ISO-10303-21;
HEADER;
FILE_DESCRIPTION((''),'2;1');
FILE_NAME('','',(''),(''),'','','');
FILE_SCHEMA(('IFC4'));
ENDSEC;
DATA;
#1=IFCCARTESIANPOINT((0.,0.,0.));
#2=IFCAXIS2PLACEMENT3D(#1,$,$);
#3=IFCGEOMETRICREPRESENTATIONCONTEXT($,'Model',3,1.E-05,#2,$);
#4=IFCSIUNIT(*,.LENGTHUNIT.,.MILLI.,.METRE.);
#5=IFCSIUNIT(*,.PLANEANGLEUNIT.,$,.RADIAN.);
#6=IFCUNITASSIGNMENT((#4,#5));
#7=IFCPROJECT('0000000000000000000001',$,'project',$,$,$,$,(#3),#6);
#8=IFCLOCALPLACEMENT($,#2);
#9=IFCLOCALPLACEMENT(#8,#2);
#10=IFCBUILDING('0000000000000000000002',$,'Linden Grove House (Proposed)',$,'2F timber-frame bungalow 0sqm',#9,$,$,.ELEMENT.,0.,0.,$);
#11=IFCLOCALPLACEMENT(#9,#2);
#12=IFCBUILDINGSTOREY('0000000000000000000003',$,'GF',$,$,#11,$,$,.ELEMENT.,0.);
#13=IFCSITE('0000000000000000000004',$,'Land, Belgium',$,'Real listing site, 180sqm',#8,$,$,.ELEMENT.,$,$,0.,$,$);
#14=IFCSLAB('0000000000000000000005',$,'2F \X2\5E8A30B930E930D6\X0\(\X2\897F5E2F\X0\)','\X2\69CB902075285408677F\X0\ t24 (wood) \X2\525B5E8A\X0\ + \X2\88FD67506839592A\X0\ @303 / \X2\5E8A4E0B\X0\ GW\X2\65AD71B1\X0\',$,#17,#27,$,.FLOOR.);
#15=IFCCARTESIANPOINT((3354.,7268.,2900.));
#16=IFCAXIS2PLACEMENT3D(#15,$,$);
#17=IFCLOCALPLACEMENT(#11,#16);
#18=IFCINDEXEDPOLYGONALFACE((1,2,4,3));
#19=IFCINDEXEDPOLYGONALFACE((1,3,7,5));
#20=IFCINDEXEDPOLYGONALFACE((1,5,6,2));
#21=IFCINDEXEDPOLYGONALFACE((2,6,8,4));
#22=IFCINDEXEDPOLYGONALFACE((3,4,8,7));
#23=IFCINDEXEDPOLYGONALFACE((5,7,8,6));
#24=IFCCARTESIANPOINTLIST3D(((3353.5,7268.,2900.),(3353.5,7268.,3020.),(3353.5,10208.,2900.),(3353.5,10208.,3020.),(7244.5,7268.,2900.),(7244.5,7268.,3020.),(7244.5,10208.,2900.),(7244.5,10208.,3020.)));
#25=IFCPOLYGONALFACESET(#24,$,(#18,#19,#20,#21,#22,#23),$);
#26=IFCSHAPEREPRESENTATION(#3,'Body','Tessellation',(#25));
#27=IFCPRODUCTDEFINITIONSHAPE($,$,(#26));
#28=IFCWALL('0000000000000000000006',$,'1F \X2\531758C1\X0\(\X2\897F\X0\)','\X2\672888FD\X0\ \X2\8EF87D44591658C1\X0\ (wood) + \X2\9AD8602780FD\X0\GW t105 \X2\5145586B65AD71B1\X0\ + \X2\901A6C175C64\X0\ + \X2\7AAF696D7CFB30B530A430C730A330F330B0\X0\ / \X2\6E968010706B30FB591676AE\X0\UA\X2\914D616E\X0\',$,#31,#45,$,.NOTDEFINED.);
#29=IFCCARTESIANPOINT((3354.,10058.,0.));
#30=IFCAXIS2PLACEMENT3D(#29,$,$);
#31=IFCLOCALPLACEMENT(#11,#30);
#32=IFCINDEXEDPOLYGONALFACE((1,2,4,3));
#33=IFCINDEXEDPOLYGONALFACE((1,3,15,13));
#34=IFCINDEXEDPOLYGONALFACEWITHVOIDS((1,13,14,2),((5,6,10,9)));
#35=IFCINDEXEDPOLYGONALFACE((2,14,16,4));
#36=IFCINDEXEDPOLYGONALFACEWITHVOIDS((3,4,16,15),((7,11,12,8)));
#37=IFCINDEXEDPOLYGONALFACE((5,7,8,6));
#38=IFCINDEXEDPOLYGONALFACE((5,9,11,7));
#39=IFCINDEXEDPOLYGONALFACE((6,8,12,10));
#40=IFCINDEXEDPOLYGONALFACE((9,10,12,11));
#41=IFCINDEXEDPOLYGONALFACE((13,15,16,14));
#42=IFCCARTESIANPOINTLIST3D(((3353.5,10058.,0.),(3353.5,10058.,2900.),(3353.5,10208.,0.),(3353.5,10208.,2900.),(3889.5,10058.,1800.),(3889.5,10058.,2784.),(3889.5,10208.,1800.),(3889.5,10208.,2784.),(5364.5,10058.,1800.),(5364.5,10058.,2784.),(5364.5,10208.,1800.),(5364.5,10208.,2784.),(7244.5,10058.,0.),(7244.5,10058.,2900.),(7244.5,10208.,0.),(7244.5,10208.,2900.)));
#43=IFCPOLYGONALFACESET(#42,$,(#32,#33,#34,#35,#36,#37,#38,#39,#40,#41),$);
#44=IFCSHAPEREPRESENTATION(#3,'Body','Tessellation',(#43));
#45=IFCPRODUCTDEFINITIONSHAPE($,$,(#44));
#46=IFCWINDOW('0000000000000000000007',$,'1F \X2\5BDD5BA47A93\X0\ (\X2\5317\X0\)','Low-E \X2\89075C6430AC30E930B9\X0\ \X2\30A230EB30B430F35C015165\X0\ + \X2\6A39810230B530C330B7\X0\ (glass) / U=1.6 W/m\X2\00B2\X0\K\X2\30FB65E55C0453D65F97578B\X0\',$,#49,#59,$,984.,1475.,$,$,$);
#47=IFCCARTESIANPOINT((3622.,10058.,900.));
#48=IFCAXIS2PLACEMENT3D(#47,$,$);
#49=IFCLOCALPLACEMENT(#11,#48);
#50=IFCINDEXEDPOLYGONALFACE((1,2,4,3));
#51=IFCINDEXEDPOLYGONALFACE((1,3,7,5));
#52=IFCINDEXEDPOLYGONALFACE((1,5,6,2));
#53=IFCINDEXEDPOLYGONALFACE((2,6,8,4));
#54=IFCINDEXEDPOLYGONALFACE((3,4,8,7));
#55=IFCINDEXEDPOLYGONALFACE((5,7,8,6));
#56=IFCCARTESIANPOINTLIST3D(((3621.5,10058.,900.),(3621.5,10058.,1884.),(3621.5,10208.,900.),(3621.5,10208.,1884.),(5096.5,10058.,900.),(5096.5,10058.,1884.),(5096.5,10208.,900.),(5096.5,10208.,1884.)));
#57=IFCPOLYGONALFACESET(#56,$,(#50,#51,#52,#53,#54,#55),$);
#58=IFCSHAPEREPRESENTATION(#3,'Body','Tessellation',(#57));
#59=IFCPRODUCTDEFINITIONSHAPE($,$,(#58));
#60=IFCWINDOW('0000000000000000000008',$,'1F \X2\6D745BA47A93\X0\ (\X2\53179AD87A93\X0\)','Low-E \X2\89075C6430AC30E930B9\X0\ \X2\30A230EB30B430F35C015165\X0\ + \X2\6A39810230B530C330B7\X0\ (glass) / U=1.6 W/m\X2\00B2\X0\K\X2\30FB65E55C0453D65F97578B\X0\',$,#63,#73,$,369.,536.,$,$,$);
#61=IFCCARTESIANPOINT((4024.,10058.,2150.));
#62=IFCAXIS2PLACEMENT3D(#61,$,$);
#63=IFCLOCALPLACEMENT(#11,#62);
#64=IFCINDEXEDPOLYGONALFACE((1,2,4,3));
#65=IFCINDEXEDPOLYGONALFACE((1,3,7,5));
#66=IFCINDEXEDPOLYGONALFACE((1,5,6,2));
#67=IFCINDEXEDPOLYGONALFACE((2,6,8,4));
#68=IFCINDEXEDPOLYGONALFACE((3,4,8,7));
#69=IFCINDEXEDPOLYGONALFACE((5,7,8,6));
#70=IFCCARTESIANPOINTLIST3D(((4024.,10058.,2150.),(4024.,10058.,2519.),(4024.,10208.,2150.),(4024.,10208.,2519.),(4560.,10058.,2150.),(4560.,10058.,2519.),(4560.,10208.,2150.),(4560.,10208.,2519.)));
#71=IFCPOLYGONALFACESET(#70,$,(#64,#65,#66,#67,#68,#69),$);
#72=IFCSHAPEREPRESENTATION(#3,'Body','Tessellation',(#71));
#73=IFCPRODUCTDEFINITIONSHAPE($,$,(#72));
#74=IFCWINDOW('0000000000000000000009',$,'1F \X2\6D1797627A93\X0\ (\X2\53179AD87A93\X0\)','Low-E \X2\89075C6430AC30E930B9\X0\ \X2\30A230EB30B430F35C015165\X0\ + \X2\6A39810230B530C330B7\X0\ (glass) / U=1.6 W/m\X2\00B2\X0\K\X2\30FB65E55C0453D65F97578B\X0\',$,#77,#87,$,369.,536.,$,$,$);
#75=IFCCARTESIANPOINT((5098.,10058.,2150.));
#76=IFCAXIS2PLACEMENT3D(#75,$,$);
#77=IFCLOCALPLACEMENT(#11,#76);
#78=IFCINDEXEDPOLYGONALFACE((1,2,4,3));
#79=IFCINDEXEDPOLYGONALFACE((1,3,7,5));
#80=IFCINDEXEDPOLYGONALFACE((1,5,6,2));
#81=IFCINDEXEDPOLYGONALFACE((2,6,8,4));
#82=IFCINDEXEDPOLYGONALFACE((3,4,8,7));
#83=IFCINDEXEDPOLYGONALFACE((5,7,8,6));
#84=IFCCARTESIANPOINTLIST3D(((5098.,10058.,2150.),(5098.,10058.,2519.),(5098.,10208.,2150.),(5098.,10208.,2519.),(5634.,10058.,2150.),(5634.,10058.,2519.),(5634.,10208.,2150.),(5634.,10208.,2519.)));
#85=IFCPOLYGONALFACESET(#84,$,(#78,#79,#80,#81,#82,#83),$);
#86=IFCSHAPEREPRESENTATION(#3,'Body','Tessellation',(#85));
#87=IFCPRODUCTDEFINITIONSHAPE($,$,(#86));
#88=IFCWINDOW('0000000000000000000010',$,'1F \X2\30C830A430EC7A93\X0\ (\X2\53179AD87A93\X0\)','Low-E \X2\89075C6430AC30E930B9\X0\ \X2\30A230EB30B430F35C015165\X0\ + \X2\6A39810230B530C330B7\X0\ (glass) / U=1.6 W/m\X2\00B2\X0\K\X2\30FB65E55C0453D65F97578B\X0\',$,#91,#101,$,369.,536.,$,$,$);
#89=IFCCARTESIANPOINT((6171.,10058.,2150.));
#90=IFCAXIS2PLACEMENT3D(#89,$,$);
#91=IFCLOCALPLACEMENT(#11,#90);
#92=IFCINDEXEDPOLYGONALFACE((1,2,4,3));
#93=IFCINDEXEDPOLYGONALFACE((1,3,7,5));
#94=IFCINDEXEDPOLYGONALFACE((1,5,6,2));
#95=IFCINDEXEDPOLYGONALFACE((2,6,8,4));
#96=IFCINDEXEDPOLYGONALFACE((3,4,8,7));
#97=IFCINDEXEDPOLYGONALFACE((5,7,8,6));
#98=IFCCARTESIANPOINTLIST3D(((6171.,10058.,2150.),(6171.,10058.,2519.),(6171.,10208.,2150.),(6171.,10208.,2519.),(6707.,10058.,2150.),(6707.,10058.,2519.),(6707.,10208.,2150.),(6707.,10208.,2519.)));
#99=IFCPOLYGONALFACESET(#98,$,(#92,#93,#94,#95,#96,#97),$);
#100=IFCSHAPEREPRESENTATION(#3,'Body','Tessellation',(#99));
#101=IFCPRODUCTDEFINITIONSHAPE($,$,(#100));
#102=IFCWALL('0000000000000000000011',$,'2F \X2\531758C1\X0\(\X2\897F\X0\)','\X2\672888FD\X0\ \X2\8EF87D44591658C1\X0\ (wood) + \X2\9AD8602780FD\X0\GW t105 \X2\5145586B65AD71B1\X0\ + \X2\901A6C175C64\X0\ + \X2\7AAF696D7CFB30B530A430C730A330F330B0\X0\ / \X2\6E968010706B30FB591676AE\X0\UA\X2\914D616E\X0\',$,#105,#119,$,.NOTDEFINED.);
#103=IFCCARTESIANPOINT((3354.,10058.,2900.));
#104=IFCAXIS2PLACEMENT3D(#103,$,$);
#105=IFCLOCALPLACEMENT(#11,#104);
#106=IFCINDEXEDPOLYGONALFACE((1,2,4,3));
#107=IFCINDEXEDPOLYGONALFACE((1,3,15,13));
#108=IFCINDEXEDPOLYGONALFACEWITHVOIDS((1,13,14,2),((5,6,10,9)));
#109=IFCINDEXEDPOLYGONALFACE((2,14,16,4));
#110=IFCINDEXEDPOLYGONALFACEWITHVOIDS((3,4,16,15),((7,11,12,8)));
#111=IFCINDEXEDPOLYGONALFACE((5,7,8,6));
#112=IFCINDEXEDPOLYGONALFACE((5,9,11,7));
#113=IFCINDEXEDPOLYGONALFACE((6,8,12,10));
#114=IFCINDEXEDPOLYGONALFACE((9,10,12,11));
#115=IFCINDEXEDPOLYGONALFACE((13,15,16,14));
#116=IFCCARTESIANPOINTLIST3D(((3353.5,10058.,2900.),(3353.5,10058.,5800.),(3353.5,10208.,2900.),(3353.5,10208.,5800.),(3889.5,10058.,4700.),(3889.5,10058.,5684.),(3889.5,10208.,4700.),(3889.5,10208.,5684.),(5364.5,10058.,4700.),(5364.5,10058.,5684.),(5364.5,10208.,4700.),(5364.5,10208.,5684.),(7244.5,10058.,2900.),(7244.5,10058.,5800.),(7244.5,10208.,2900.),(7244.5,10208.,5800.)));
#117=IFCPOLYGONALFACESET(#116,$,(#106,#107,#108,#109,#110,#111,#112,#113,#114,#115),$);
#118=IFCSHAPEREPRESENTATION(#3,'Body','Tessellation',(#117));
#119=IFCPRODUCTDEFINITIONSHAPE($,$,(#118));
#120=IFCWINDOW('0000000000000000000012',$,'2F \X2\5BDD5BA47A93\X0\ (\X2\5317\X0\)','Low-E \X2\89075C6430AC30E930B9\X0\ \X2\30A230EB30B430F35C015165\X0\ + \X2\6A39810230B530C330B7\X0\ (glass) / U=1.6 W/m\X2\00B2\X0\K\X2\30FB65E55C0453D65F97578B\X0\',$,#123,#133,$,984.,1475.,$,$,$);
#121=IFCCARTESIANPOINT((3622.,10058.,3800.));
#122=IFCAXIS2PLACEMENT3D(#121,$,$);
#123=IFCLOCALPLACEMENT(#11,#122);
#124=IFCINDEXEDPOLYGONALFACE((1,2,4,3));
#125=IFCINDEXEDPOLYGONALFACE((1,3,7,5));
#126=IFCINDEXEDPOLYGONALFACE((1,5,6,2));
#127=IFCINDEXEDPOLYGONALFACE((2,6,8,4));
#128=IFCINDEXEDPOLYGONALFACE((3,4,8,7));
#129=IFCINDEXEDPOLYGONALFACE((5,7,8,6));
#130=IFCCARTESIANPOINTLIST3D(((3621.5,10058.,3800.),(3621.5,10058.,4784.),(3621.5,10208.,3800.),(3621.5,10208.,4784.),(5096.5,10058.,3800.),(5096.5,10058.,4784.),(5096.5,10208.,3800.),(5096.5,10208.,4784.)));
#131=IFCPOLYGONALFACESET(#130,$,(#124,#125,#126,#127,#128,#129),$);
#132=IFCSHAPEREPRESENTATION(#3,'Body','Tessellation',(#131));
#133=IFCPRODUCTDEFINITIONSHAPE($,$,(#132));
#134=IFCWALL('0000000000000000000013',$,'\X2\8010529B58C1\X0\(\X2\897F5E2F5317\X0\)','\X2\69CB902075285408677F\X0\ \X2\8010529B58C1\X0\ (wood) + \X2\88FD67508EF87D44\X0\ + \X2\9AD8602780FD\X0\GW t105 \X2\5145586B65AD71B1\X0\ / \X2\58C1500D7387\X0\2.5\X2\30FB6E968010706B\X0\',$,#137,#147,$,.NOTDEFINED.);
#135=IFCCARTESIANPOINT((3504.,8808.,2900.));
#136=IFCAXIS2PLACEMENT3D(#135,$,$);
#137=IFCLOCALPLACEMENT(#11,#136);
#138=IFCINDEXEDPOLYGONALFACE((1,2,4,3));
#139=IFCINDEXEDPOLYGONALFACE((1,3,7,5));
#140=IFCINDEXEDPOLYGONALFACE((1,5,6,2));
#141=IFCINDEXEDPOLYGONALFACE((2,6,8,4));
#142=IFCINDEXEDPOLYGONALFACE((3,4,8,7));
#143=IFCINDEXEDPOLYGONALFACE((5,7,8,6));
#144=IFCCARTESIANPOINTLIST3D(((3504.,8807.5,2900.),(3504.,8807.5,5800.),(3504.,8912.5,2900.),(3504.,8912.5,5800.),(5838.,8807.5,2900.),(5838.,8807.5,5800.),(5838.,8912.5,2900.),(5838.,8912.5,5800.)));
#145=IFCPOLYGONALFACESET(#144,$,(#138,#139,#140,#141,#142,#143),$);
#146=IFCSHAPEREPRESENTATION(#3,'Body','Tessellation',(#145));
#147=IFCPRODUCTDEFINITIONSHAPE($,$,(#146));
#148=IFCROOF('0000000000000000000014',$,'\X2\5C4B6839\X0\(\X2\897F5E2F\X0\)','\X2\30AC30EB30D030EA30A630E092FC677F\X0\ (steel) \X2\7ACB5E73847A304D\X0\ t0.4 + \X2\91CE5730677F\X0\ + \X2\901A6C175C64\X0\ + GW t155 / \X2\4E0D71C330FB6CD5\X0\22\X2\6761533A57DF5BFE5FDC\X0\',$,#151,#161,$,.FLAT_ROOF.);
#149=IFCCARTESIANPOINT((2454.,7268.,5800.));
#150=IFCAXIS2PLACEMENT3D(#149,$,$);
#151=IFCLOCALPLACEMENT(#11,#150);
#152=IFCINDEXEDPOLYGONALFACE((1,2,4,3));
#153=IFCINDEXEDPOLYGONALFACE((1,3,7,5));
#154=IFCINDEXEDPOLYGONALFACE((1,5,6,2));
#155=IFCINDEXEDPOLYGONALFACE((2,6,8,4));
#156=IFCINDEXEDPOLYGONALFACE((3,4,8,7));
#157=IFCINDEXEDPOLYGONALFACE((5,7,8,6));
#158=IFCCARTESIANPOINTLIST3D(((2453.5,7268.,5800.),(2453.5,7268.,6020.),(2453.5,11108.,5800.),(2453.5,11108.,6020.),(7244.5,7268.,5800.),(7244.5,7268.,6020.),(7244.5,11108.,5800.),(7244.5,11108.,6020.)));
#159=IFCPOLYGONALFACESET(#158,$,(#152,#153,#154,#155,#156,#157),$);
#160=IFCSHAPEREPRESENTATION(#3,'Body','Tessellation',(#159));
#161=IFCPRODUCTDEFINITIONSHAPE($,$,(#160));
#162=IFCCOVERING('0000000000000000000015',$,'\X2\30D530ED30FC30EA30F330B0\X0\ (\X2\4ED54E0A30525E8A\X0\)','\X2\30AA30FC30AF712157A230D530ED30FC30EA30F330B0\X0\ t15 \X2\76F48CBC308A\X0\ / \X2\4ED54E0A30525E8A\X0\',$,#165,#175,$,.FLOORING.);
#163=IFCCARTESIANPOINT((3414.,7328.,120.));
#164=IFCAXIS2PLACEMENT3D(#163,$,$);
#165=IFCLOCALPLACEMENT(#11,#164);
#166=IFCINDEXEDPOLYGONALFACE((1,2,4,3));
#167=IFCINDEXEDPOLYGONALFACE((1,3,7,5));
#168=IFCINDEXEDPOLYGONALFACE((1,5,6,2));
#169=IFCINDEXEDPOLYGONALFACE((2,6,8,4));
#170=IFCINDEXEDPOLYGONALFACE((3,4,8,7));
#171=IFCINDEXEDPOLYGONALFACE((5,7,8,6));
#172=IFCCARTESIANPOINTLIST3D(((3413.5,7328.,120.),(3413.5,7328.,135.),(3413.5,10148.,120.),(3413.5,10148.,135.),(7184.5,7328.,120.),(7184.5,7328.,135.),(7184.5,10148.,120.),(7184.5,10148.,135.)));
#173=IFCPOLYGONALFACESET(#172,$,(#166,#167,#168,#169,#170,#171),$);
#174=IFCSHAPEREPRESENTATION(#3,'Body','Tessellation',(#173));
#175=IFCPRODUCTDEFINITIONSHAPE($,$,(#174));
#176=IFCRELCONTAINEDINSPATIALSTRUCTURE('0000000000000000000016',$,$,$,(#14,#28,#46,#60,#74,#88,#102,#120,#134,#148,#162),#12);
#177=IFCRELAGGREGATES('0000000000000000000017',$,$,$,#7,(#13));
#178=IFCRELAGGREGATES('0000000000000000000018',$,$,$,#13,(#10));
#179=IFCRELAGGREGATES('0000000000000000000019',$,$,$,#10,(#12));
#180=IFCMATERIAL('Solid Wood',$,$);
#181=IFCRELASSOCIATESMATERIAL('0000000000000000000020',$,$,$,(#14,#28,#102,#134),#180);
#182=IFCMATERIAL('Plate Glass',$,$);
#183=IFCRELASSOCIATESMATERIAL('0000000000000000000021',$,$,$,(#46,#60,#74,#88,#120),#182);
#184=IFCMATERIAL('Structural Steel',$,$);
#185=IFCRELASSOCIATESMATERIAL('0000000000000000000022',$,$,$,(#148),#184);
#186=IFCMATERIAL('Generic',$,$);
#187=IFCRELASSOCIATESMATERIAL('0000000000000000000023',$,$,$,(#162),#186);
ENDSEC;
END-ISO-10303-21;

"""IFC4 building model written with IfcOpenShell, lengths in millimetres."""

from ifc_helpers import new_model, si_unit, frame, frame_2d, origin, place, context, project, spatial, rectangle, extrude, material, element, fill, save


model = new_model("IFC4")

# Units and contexts
model_context = context("Model", 3, precision=1e-05, world=origin())
ifc_project = project(units=[si_unit("LENGTHUNIT", "METRE", prefix="MILLI"), si_unit("PLANEANGLEUNIT", "RADIAN")], contexts=[model_context])

# Site, building, storey
site_placement = place(None, origin())
site = spatial("IfcSite", under=ifc_project, at=site_placement, Name="Land, Belgium", ObjectType="Real listing site, 180sqm", CompositionType="ELEMENT", RefElevation=0.0)
building_placement = place(site_placement, origin())
building = spatial("IfcBuilding", under=site, at=building_placement, Name="Linden Grove House (Proposed)", ObjectType="2F timber-frame bungalow 0sqm", CompositionType="ELEMENT", ElevationOfRefHeight=0.0, ElevationOfTerrain=0.0)
storey_placement = place(building_placement, origin())
storey = spatial("IfcBuildingStorey", under=building, at=storey_placement, Name="GF", CompositionType="ELEMENT", Elevation=0.0)

# Slab
ifc_material_1 = material(Name="Solid Wood")
slab_1_placement = place(storey_placement, frame((3354.0, 7268.0, 2900.0)))
element("IfcSlab", 1, at=slab_1_placement, inside=storey, material=ifc_material_1, Name="2F 床スラブ(西帯)", Description="構造用合板 t24 (wood) 剛床 + 製材根太 @303 / 床下 GW断熱", PredefinedType="FLOOR", context=model_context, shape_type="SweptSolid", body=[
    extrude(rectangle(XDim=3891.0, YDim=2940.0, at=frame_2d((1945.0, 1470.0))), frame((3354.0, 7268.0, 2900.0)), (0.0, 0.0, 1.0), 120.0),
])

# Wall, openings, windows
wall_1_placement = place(storey_placement, frame((3354.0, 10058.0, 0.0)))
wall_1 = element("IfcWall", 2, at=wall_1_placement, inside=storey, material=ifc_material_1, Name="1F 北壁(西)", Description="木製 軸組外壁 (wood) + 高性能GW t105 充填断熱 + 通気層 + 窯業系サイディング / 準耐火・外皮UA配慮", PredefinedType="NOTDEFINED", context=model_context, shape_type="SweptSolid", body=[
    extrude(rectangle(XDim=3891.0, YDim=150.0, at=frame_2d((1945.0, 75.0))), frame((3354.0, 10058.0, 0.0)), (0.0, 0.0, 1.0), 2900.0),
])
opening_1_placement = place(storey_placement, frame((3622.0, 10058.0, 900.0)))
opening_1 = element("IfcOpeningElement", 3, at=opening_1_placement, cuts=wall_1, PredefinedType="NOTDEFINED", context=model_context, shape_type="SweptSolid", body=[
    extrude(rectangle(XDim=1475.0, YDim=150.0, at=frame_2d((737.0, 75.0))), frame((3622.0, 10058.0, 900.0)), (0.0, 0.0, 1.0), 984.0),
])
opening_2_placement = place(storey_placement, frame((4024.0, 10058.0, 2150.0)))
opening_2 = element("IfcOpeningElement", 4, at=opening_2_placement, cuts=wall_1, PredefinedType="NOTDEFINED", context=model_context, shape_type="SweptSolid", body=[
    extrude(rectangle(XDim=536.0, YDim=150.0, at=frame_2d((268.0, 75.0))), frame((4024.0, 10058.0, 2150.0)), (0.0, 0.0, 1.0), 369.0),
])
opening_3_placement = place(storey_placement, frame((5098.0, 10058.0, 2150.0)))
opening_3 = element("IfcOpeningElement", 5, at=opening_3_placement, cuts=wall_1, PredefinedType="NOTDEFINED", context=model_context, shape_type="SweptSolid", body=[
    extrude(rectangle(XDim=536.0, YDim=150.0, at=frame_2d((268.0, 75.0))), frame((5098.0, 10058.0, 2150.0)), (0.0, 0.0, 1.0), 369.0),
])
opening_4_placement = place(storey_placement, frame((6171.0, 10058.0, 2150.0)))
opening_4 = element("IfcOpeningElement", 6, at=opening_4_placement, cuts=wall_1, PredefinedType="NOTDEFINED", context=model_context, shape_type="SweptSolid", body=[
    extrude(rectangle(XDim=536.0, YDim=150.0, at=frame_2d((268.0, 75.0))), frame((6171.0, 10058.0, 2150.0)), (0.0, 0.0, 1.0), 369.0),
])
ifc_material_2 = material(Name="Plate Glass")
window_1_placement = place(storey_placement, frame((3622.0, 10058.0, 900.0)))
window_1 = element("IfcWindow", 7, at=window_1_placement, inside=storey, material=ifc_material_2, Name="1F 寝室窓 (北)", Description="Low-E 複層ガラス アルゴン封入 + 樹脂サッシ (glass) / U=1.6 W/m²K・日射取得型", OverallHeight=984.0, OverallWidth=1475.0, context=model_context, shape_type="SweptSolid", body=[
    extrude(rectangle(XDim=1475.0, YDim=150.0, at=frame_2d((737.0, 75.0))), frame((3622.0, 10058.0, 900.0)), (0.0, 0.0, 1.0), 984.0),
])
fill(opening_1, window_1)
window_2_placement = place(storey_placement, frame((4024.0, 10058.0, 2150.0)))
window_2 = element("IfcWindow", 8, at=window_2_placement, inside=storey, material=ifc_material_2, Name="1F 浴室窓 (北高窓)", Description="Low-E 複層ガラス アルゴン封入 + 樹脂サッシ (glass) / U=1.6 W/m²K・日射取得型", OverallHeight=369.0, OverallWidth=536.0, context=model_context, shape_type="SweptSolid", body=[
    extrude(rectangle(XDim=536.0, YDim=150.0, at=frame_2d((268.0, 75.0))), frame((4024.0, 10058.0, 2150.0)), (0.0, 0.0, 1.0), 369.0),
])
fill(opening_2, window_2)
window_3_placement = place(storey_placement, frame((5098.0, 10058.0, 2150.0)))
window_3 = element("IfcWindow", 9, at=window_3_placement, inside=storey, material=ifc_material_2, Name="1F 洗面窓 (北高窓)", Description="Low-E 複層ガラス アルゴン封入 + 樹脂サッシ (glass) / U=1.6 W/m²K・日射取得型", OverallHeight=369.0, OverallWidth=536.0, context=model_context, shape_type="SweptSolid", body=[
    extrude(rectangle(XDim=536.0, YDim=150.0, at=frame_2d((268.0, 75.0))), frame((5098.0, 10058.0, 2150.0)), (0.0, 0.0, 1.0), 369.0),
])
fill(opening_3, window_3)
window_4_placement = place(storey_placement, frame((6171.0, 10058.0, 2150.0)))
window_4 = element("IfcWindow", 10, at=window_4_placement, inside=storey, material=ifc_material_2, Name="1F トイレ窓 (北高窓)", Description="Low-E 複層ガラス アルゴン封入 + 樹脂サッシ (glass) / U=1.6 W/m²K・日射取得型", OverallHeight=369.0, OverallWidth=536.0, context=model_context, shape_type="SweptSolid", body=[
    extrude(rectangle(XDim=536.0, YDim=150.0, at=frame_2d((268.0, 75.0))), frame((6171.0, 10058.0, 2150.0)), (0.0, 0.0, 1.0), 369.0),
])
fill(opening_4, window_4)

# Wall, opening, window
wall_2_placement = place(storey_placement, frame((3354.0, 10058.0, 2900.0)))
wall_2 = element("IfcWall", 11, at=wall_2_placement, inside=storey, material=ifc_material_1, Name="2F 北壁(西)", Description="木製 軸組外壁 (wood) + 高性能GW t105 充填断熱 + 通気層 + 窯業系サイディング / 準耐火・外皮UA配慮", PredefinedType="NOTDEFINED", context=model_context, shape_type="SweptSolid", body=[
    extrude(rectangle(XDim=3891.0, YDim=150.0, at=frame_2d((1945.0, 75.0))), frame((3354.0, 10058.0, 2900.0)), (0.0, 0.0, 1.0), 2900.0),
])
opening_5_placement = place(storey_placement, frame((3622.0, 10058.0, 3800.0)))
opening_5 = element("IfcOpeningElement", 12, at=opening_5_placement, cuts=wall_2, PredefinedType="NOTDEFINED", context=model_context, shape_type="SweptSolid", body=[
    extrude(rectangle(XDim=1475.0, YDim=150.0, at=frame_2d((737.0, 75.0))), frame((3622.0, 10058.0, 3800.0)), (0.0, 0.0, 1.0), 984.0),
])
window_5_placement = place(storey_placement, frame((3622.0, 10058.0, 3800.0)))
window_5 = element("IfcWindow", 13, at=window_5_placement, inside=storey, material=ifc_material_2, Name="2F 寝室窓 (北)", Description="Low-E 複層ガラス アルゴン封入 + 樹脂サッシ (glass) / U=1.6 W/m²K・日射取得型", OverallHeight=984.0, OverallWidth=1475.0, context=model_context, shape_type="SweptSolid", body=[
    extrude(rectangle(XDim=1475.0, YDim=150.0, at=frame_2d((737.0, 75.0))), frame((3622.0, 10058.0, 3800.0)), (0.0, 0.0, 1.0), 984.0),
])
fill(opening_5, window_5)

# Wall
wall_3_placement = place(storey_placement, frame((3504.0, 8808.0, 2900.0)))
element("IfcWall", 14, at=wall_3_placement, inside=storey, material=ifc_material_1, Name="耐力壁(西帯北)", Description="構造用合板 耐力壁 (wood) + 製材軸組 + 高性能GW t105 充填断熱 / 壁倍率2.5・準耐火", PredefinedType="NOTDEFINED", context=model_context, shape_type="SweptSolid", body=[
    extrude(rectangle(XDim=2334.0, YDim=105.0, at=frame_2d((1167.0, 52.0))), frame((3504.0, 8808.0, 2900.0)), (0.0, 0.0, 1.0), 2900.0),
])

# Roof
ifc_material_3 = material(Name="Structural Steel")
for number, where, name in (
    (15, (2454.0, 7268.0, 5800.0), "屋根(西帯)"),
):
    element("IfcRoof", number, at=place(storey_placement, frame(where)), inside=storey, material=ifc_material_3, Name=name, Description="ガルバリウム鋼板 (steel) 立平葺き t0.4 + 野地板 + 通気層 + GW t155 / 不燃・法22条区域対応", PredefinedType="FLAT_ROOF", context=model_context, shape_type="SweptSolid", body=[
        extrude(rectangle(XDim=4791.0, YDim=3840.0, at=frame_2d((2395.0, 1920.0))), frame((2454.0, 7268.0, 5800.0)), (0.0, 0.0, 1.0), 220.0),
    ])

# Covering
ifc_material_4 = material(Name="Generic")
covering_1_placement = place(storey_placement, frame((3414.0, 7328.0, 120.0)))
element("IfcCovering", 16, at=covering_1_placement, inside=storey, material=ifc_material_4, Name="フローリング (仕上げ床)", Description="オーク無垢フローリング t15 直貼り / 仕上げ床", PredefinedType="FLOORING", context=model_context, shape_type="SweptSolid", body=[
    extrude(rectangle(XDim=3771.0, YDim=2820.0, at=frame_2d((1885.0, 1410.0))), frame((3414.0, 7328.0, 120.0)), (0.0, 0.0, 1.0), 15.0),
])

save(model, "model.ifc")
